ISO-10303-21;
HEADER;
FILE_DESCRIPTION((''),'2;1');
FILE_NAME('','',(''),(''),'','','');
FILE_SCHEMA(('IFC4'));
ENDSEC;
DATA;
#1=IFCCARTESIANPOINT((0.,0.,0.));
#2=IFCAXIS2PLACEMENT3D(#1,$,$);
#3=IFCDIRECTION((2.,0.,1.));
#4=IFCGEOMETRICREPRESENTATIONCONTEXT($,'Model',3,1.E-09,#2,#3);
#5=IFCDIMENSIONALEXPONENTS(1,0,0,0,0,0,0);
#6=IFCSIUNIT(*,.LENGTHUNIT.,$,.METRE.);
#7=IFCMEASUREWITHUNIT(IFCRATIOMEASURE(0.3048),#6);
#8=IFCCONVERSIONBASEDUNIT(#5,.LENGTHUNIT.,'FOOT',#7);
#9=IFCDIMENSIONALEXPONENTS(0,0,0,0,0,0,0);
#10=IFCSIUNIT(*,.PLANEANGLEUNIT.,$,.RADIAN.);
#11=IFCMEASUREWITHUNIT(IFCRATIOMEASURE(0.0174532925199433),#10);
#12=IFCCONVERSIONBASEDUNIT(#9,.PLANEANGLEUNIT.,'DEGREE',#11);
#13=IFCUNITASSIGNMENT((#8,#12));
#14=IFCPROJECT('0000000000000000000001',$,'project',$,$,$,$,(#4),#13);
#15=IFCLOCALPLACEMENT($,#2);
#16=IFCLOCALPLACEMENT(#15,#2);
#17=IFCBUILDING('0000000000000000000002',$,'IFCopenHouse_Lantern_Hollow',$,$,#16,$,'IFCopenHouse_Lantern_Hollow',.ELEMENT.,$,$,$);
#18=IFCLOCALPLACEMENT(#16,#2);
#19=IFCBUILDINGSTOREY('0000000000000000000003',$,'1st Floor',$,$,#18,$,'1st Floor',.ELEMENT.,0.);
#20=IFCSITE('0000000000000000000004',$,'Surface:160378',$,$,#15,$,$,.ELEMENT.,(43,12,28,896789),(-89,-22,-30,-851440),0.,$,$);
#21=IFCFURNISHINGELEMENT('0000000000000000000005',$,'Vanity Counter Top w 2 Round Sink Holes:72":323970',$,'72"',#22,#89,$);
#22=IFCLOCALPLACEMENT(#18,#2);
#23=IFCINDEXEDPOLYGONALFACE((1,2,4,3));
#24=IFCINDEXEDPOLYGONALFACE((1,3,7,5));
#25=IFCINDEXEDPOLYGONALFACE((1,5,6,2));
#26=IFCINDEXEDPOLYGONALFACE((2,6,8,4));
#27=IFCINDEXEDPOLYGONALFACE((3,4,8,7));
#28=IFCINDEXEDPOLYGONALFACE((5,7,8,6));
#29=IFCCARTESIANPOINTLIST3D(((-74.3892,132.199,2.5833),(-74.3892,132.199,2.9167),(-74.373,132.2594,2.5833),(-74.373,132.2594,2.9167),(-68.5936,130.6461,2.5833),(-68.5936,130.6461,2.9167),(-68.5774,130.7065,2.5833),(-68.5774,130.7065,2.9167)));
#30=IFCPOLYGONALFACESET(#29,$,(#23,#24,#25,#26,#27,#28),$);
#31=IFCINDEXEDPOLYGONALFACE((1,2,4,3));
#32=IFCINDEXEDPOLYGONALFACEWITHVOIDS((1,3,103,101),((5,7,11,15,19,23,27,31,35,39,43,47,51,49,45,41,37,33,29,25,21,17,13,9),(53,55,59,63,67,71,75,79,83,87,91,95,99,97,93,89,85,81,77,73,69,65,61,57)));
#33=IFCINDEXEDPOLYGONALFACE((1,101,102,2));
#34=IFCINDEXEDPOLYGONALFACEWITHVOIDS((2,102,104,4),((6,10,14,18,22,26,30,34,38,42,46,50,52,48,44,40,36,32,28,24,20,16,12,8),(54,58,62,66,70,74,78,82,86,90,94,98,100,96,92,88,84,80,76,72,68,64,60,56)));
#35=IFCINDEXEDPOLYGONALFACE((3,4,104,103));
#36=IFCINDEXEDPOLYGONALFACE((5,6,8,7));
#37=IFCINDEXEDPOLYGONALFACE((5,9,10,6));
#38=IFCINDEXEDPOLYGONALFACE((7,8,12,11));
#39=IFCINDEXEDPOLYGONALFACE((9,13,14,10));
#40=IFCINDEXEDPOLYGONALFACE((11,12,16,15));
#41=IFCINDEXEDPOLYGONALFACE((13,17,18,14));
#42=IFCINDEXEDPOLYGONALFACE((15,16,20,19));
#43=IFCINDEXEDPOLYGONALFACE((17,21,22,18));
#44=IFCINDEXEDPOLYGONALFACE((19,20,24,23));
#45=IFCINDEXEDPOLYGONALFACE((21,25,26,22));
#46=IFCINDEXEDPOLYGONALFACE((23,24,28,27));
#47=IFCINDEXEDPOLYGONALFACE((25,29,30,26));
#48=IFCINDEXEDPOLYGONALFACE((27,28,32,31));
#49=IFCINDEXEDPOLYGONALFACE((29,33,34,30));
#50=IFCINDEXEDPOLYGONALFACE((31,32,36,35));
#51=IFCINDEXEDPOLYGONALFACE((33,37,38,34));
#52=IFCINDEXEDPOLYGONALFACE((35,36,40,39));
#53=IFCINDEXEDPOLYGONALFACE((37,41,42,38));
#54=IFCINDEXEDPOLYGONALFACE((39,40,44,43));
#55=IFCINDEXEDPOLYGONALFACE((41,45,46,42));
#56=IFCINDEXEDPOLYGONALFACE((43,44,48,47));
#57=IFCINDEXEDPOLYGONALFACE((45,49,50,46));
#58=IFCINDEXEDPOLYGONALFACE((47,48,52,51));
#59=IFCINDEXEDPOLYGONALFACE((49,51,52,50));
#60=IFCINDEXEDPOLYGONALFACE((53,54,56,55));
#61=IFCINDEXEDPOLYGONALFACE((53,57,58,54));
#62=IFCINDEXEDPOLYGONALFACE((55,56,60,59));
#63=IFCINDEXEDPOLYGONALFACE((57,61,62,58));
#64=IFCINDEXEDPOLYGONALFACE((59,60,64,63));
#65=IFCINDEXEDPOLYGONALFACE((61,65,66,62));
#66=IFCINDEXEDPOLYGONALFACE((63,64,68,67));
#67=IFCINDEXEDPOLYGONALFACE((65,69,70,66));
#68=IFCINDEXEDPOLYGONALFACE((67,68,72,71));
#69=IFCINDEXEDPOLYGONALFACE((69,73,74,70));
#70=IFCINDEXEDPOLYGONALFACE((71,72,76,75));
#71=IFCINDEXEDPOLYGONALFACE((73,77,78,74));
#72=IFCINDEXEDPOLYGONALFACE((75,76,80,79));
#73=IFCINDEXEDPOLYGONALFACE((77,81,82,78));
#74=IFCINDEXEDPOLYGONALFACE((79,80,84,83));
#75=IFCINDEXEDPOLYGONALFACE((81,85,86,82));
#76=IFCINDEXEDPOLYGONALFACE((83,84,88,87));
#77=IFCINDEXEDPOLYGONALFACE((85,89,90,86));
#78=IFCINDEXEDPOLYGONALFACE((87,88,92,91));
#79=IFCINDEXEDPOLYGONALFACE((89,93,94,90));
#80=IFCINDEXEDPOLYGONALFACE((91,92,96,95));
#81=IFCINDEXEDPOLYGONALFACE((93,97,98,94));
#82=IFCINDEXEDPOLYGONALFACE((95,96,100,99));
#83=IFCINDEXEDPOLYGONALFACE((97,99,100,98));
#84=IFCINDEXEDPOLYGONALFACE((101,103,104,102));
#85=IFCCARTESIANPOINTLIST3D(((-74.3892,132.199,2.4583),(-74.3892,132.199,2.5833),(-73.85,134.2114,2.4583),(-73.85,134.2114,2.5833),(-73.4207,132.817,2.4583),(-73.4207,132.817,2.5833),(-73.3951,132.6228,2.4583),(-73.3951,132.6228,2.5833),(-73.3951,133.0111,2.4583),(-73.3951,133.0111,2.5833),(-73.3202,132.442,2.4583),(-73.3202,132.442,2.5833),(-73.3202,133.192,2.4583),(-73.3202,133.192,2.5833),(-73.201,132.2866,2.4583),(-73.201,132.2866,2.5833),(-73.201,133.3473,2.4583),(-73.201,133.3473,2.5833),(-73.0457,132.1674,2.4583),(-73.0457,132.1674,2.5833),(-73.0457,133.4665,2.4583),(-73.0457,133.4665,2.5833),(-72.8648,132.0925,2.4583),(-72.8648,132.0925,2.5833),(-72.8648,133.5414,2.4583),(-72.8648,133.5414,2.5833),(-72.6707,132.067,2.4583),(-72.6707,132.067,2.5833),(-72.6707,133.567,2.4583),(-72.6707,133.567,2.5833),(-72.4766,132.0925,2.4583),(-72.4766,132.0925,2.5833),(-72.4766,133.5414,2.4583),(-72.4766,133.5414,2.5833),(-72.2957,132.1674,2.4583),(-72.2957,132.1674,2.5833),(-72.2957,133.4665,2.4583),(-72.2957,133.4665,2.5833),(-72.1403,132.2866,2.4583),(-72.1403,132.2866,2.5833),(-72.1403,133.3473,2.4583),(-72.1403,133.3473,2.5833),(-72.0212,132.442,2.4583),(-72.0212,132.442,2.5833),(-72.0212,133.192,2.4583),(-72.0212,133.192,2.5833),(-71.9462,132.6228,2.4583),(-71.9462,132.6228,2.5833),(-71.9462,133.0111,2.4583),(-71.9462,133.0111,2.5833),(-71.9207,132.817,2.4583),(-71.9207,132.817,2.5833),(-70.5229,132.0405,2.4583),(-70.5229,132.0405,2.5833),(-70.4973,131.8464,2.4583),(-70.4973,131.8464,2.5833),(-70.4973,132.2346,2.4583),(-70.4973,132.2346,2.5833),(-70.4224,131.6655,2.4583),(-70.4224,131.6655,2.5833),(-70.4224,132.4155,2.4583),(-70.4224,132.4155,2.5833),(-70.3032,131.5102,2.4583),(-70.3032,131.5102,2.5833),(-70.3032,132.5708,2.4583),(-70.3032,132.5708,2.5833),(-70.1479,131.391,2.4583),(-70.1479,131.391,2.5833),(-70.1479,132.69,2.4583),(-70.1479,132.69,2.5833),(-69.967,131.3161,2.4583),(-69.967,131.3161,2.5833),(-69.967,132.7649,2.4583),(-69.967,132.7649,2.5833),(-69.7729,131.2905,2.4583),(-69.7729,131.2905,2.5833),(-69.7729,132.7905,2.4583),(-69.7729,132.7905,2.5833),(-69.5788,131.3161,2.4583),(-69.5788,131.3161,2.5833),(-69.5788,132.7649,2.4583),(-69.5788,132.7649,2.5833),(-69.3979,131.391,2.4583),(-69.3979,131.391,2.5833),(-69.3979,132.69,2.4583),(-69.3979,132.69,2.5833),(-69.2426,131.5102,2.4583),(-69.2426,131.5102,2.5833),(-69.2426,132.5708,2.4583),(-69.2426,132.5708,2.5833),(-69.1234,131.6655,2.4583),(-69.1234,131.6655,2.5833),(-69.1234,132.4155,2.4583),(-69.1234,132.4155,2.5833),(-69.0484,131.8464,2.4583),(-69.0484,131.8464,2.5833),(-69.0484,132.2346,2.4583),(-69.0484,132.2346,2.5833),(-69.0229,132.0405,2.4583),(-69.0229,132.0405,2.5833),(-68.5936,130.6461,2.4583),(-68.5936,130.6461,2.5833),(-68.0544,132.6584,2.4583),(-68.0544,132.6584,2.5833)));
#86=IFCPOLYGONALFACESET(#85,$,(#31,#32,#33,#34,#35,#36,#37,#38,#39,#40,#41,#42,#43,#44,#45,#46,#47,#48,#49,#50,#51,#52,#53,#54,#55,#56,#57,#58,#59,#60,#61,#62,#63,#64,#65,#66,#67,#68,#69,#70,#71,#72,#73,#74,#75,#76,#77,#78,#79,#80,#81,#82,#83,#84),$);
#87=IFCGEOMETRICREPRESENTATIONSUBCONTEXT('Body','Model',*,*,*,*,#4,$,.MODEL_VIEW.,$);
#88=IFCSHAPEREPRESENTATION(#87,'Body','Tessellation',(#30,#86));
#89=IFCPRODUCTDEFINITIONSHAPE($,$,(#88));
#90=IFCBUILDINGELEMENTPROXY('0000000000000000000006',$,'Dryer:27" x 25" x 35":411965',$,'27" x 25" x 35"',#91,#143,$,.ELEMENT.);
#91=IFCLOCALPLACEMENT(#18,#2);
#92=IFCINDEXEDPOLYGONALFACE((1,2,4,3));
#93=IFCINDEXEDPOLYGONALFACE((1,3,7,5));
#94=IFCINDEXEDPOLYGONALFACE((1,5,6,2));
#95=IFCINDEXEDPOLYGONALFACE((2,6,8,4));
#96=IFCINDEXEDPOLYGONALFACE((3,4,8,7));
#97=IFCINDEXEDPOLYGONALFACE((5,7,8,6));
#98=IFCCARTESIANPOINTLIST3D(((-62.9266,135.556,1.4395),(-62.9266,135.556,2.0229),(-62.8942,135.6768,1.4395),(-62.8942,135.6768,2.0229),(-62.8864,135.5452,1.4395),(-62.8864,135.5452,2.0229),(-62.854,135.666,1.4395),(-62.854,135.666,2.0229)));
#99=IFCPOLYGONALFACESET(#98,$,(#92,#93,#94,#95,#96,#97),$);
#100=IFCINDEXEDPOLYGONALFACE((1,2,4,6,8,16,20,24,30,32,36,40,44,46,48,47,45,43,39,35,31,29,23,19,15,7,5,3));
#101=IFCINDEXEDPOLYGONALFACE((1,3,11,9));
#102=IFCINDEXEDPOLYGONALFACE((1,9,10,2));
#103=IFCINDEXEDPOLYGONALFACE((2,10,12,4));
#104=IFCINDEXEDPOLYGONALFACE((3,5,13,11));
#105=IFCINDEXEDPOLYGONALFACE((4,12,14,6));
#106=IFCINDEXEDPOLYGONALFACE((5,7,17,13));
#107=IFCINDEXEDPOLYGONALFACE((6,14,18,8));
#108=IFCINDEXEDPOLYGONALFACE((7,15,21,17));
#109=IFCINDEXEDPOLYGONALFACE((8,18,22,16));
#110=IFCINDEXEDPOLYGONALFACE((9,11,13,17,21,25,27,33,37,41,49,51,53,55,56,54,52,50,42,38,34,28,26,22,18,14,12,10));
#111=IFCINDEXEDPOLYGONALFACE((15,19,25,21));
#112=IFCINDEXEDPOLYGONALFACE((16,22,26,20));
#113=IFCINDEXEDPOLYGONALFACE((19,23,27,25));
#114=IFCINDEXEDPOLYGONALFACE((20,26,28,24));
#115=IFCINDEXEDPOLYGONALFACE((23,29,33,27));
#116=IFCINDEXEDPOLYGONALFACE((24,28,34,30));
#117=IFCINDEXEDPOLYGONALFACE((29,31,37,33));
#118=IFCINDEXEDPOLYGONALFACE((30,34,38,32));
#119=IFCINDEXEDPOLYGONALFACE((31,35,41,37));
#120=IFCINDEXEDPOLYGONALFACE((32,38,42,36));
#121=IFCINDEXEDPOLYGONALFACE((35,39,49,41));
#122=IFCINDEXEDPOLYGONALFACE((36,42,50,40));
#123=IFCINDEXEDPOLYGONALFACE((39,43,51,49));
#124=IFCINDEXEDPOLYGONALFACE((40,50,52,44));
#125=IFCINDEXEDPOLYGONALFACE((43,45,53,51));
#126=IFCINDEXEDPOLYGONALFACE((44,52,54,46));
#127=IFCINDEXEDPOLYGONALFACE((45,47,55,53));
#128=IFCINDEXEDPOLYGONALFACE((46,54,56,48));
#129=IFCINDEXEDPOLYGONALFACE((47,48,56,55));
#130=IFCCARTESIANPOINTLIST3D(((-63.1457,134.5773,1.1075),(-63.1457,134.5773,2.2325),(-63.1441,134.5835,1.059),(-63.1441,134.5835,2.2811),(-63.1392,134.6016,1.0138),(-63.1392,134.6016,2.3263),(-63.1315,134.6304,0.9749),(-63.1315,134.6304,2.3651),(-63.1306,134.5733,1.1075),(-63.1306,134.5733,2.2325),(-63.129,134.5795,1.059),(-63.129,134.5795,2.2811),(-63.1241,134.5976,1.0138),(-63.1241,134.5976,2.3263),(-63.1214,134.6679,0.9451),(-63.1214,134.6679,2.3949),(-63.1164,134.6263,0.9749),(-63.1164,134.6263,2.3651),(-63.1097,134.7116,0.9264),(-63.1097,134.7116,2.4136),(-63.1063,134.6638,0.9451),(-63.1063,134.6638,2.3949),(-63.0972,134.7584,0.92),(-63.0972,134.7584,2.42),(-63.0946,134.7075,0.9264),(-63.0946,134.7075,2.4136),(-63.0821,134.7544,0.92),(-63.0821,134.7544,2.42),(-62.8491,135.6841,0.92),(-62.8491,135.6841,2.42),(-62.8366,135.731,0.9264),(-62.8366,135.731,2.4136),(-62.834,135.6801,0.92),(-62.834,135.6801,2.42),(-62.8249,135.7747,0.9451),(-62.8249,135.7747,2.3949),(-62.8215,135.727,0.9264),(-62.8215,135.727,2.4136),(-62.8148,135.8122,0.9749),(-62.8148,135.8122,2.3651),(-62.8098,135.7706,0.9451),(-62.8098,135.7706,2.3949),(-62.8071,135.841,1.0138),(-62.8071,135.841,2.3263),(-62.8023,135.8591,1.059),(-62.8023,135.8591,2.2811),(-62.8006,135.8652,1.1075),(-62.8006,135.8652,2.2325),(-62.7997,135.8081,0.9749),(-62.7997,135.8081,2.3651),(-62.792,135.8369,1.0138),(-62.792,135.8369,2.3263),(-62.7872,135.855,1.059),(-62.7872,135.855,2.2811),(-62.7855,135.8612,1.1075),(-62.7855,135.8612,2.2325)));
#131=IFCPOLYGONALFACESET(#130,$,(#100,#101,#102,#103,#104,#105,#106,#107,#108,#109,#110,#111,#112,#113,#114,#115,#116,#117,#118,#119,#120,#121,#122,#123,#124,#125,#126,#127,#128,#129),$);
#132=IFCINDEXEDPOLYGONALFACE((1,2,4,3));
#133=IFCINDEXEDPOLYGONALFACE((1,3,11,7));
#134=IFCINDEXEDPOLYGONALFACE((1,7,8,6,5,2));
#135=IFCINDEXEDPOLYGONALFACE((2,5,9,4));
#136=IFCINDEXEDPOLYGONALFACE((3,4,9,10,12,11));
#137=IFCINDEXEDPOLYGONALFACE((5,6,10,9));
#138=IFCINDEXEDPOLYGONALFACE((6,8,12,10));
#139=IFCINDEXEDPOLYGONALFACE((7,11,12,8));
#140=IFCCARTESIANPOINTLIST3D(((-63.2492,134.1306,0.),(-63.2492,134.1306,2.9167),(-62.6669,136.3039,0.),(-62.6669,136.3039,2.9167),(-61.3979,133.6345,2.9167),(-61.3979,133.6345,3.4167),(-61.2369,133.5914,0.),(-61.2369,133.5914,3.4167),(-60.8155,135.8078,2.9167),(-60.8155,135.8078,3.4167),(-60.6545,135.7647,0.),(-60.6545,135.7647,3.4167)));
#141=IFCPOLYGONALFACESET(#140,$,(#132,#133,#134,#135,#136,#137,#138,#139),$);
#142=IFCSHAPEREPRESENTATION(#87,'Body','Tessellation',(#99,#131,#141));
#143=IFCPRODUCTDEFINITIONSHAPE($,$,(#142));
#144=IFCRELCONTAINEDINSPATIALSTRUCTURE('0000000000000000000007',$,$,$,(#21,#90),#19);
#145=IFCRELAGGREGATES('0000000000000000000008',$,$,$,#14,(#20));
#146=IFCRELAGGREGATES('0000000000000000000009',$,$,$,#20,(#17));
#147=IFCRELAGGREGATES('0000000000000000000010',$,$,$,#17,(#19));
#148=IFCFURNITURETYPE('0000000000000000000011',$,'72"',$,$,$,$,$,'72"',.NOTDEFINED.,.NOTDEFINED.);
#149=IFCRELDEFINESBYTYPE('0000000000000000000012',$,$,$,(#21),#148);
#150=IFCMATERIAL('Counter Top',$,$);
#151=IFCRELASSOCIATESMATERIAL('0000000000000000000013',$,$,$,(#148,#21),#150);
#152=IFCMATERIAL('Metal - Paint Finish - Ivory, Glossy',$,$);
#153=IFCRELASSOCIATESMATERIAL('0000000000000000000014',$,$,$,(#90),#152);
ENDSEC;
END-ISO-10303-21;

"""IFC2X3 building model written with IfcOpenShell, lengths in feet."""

from ifc_helpers import new_model, entity, si_unit, converted_unit, direction, frame, frame_2d, origin, origin_2d_with_axis, place, context, subcontext, project, spatial, polyline, circle_curve, parameter, trimmed, segment, composite_curve, rectangle, outline, extrude, source, transform, mapped, material, type_object, type_shapes, element, save


model = new_model("IFC2X3")

# Units and contexts
model_context = context("Model", 3, precision=1e-09, world=origin(), true_north=direction((2.0, 0.0, 1.0)))
body_context = subcontext(model_context, "Body", "Model", "MODEL_VIEW")
ifc_project = project(units=[converted_unit("LENGTHUNIT", "FOOT", entity("IfcRatioMeasure", 0.3048), si_unit("LENGTHUNIT", "METRE"), dimensions=[1, 0, 0, 0, 0, 0, 0]), converted_unit("PLANEANGLEUNIT", "DEGREE", entity("IfcRatioMeasure", 0.0174532925199433), si_unit("PLANEANGLEUNIT", "RADIAN"), dimensions=[0, 0, 0, 0, 0, 0, 0])], contexts=[model_context])

# Site, building, storey
site_placement = place(None, origin())
site = spatial("IfcSite", under=ifc_project, at=site_placement, Name="Surface:160378", CompositionType="ELEMENT", RefLatitude=(43, 12, 28, 896789), RefLongitude=(-89, -22, -30, -851440), RefElevation=0.0)
building_placement = place(site_placement, origin())
building = spatial("IfcBuilding", under=site, at=building_placement, Name="IFCopenHouse_Lantern_Hollow", LongName="IFCopenHouse_Lantern_Hollow", CompositionType="ELEMENT")
storey_placement = place(building_placement, origin())
storey = spatial("IfcBuildingStorey", under=building, at=storey_placement, Name="1st Floor", LongName="1st Floor", CompositionType="ELEMENT", Elevation=0.0)

# Furnishing element
ifc_material_1 = material(Name="Counter Top")
furniture_type = type_object("IfcFurnitureType", Name="72\"", ElementType="72\"", AssemblyPlace="NOTDEFINED", material=ifc_material_1)
shared_shape_1 = source(origin(), body_context, "Body", "SweptSolid", [
    extrude(rectangle(XDim=6.0, YDim=0.0625, at=origin_2d_with_axis()), frame((3.0, 0.0313, 0.125)), (0.0, 0.0, 1.0), 0.3333),
    extrude(outline(polyline([(-1.0417, -3.0), (1.0417, -3.0), (1.0417, 3.0), (-1.0417, 3.0), (-1.0417, -3.0)]), holes=[composite_curve([segment(trimmed(circle_curve(frame_2d((0.0, 1.5), x_axis=(0.0, -1.0)), 0.75), [parameter(180.0)], [parameter(0.0)], True, "PARAMETER"), False, "CONTINUOUS"), segment(trimmed(circle_curve(frame_2d((0.0, 1.5), x_axis=(0.0, -1.0)), 0.75), [parameter(360.0)], [parameter(180.0)], True, "PARAMETER"), False, "CONTINUOUS")], self_intersect=False), composite_curve([segment(trimmed(circle_curve(frame_2d((0.0, -1.5), x_axis=(0.0, -1.0)), 0.75), [parameter(180.0)], [parameter(360.0)], True, "PARAMETER"), False, "CONTINUOUS"), segment(trimmed(circle_curve(frame_2d((0.0, -1.5), x_axis=(0.0, -1.0)), 0.75), [parameter(0.0)], [parameter(180.0)], True, "PARAMETER"), False, "CONTINUOUS")], self_intersect=False)]), frame((3.0, 1.0417, 0.0), z_axis=(0.0, 0.0, 1.0), x_axis=(0.0, 1.0, 0.0)), (0.0, 0.0, 1.0), 0.125),
])
type_shapes(furniture_type, [shared_shape_1])
furnishing_placement = place(storey_placement, frame((-74.3892, 132.199, 2.4583), z_axis=(0.0, 0.0, 1.0), x_axis=(0.965926, -0.258819, 0.0)))
element("IfcFurnishingElement", 1, at=furnishing_placement, inside=storey, type_object=furniture_type, material=ifc_material_1, Name="Vanity Counter Top w 2 Round Sink Holes:72\":323970", ObjectType="72\"", context=body_context, shape_type="MappedRepresentation", body=[
    mapped(shared_shape_1, transform((0.0, 0.0, 0.0), scale=1.0)),
])

# Building element proxy
ifc_material_2 = material(Name="Metal - Paint Finish - Ivory, Glossy")
shared_shape_2 = source(origin(), body_context, "Body", "SweptSolid", [
    extrude(rectangle(XDim=0.0417, YDim=0.125, at=frame_2d((0.0, 0.0), x_axis=(1.0, 0.0))), frame((0.7271, 0.0208, 1.4395), z_axis=(0.0, 0.0, 1.0), x_axis=(0.0, 1.0, 0.0)), (0.0, 0.0, 1.0), 0.5833),
    extrude(outline(composite_curve([segment(trimmed(circle_curve(frame_2d((-0.4792, 0.5625), x_axis=(1.0, 0.0)), 0.1875), [parameter(90.0)], [parameter(180.0)], True, "PARAMETER"), True, "CONTINUOUS"), segment(polyline([(-0.6667, 0.5625), (-0.6667, -0.5625)]), True, "CONTINUOUS"), segment(trimmed(circle_curve(frame_2d((-0.4792, -0.5625), x_axis=(1.0, 0.0)), 0.1875), [parameter(180.0)], [parameter(270.0)], True, "PARAMETER"), True, "CONTINUOUS"), segment(polyline([(-0.4792, -0.75), (0.4792, -0.75)]), True, "CONTINUOUS"), segment(trimmed(circle_curve(frame_2d((0.4792, -0.5625), x_axis=(1.0, 0.0)), 0.1875), [parameter(270.0)], [parameter(0.0)], True, "PARAMETER"), True, "CONTINUOUS"), segment(polyline([(0.6667, -0.5625), (0.6667, 0.5625)]), True, "CONTINUOUS"), segment(trimmed(circle_curve(frame_2d((0.4792, 0.5625), x_axis=(1.0, 0.0)), 0.1875), [parameter(0.0)], [parameter(90.0)], True, "PARAMETER"), True, "CONTINUOUS"), segment(polyline([(0.4792, 0.75), (-0.4792, 0.75)]), True, "CONTINUOUS")], self_intersect=False)), frame((1.125, 0.0417, 1.67), z_axis=(0.0, 1.0, 0.0), x_axis=(-1.0, 0.0, 0.0)), (0.0, 0.0, 1.0), 0.0156),
    extrude(outline(polyline([(-2.1111, -0.75), (1.3056, -0.75), (1.3056, -0.5833), (0.8056, -0.5833), (0.8056, 1.3333), (-2.1111, 1.3333), (-2.1111, -0.75)])), frame((0.0, 1.3906, 2.1111), z_axis=(1.0, 0.0, 0.0), x_axis=(0.0, 0.0, 1.0)), (0.0, 0.0, 1.0), 2.25),
])
proxy_placement = place(storey_placement, frame((-62.7222, 136.3187, 0.0), z_axis=(0.0, 0.0, 1.0), x_axis=(-0.258819, -0.965926, 0.0)))
element("IfcBuildingElementProxy", 2, at=proxy_placement, inside=storey, material=ifc_material_2, Name="Dryer:27\" x 25\" x 35\":411965", ObjectType="27\" x 25\" x 35\"", CompositionType="ELEMENT", context=body_context, shape_type="MappedRepresentation", body=[
    mapped(shared_shape_2, transform((0.0, 0.0, 0.0), scale=1.0)),
])

save(model, "model.ifc")
